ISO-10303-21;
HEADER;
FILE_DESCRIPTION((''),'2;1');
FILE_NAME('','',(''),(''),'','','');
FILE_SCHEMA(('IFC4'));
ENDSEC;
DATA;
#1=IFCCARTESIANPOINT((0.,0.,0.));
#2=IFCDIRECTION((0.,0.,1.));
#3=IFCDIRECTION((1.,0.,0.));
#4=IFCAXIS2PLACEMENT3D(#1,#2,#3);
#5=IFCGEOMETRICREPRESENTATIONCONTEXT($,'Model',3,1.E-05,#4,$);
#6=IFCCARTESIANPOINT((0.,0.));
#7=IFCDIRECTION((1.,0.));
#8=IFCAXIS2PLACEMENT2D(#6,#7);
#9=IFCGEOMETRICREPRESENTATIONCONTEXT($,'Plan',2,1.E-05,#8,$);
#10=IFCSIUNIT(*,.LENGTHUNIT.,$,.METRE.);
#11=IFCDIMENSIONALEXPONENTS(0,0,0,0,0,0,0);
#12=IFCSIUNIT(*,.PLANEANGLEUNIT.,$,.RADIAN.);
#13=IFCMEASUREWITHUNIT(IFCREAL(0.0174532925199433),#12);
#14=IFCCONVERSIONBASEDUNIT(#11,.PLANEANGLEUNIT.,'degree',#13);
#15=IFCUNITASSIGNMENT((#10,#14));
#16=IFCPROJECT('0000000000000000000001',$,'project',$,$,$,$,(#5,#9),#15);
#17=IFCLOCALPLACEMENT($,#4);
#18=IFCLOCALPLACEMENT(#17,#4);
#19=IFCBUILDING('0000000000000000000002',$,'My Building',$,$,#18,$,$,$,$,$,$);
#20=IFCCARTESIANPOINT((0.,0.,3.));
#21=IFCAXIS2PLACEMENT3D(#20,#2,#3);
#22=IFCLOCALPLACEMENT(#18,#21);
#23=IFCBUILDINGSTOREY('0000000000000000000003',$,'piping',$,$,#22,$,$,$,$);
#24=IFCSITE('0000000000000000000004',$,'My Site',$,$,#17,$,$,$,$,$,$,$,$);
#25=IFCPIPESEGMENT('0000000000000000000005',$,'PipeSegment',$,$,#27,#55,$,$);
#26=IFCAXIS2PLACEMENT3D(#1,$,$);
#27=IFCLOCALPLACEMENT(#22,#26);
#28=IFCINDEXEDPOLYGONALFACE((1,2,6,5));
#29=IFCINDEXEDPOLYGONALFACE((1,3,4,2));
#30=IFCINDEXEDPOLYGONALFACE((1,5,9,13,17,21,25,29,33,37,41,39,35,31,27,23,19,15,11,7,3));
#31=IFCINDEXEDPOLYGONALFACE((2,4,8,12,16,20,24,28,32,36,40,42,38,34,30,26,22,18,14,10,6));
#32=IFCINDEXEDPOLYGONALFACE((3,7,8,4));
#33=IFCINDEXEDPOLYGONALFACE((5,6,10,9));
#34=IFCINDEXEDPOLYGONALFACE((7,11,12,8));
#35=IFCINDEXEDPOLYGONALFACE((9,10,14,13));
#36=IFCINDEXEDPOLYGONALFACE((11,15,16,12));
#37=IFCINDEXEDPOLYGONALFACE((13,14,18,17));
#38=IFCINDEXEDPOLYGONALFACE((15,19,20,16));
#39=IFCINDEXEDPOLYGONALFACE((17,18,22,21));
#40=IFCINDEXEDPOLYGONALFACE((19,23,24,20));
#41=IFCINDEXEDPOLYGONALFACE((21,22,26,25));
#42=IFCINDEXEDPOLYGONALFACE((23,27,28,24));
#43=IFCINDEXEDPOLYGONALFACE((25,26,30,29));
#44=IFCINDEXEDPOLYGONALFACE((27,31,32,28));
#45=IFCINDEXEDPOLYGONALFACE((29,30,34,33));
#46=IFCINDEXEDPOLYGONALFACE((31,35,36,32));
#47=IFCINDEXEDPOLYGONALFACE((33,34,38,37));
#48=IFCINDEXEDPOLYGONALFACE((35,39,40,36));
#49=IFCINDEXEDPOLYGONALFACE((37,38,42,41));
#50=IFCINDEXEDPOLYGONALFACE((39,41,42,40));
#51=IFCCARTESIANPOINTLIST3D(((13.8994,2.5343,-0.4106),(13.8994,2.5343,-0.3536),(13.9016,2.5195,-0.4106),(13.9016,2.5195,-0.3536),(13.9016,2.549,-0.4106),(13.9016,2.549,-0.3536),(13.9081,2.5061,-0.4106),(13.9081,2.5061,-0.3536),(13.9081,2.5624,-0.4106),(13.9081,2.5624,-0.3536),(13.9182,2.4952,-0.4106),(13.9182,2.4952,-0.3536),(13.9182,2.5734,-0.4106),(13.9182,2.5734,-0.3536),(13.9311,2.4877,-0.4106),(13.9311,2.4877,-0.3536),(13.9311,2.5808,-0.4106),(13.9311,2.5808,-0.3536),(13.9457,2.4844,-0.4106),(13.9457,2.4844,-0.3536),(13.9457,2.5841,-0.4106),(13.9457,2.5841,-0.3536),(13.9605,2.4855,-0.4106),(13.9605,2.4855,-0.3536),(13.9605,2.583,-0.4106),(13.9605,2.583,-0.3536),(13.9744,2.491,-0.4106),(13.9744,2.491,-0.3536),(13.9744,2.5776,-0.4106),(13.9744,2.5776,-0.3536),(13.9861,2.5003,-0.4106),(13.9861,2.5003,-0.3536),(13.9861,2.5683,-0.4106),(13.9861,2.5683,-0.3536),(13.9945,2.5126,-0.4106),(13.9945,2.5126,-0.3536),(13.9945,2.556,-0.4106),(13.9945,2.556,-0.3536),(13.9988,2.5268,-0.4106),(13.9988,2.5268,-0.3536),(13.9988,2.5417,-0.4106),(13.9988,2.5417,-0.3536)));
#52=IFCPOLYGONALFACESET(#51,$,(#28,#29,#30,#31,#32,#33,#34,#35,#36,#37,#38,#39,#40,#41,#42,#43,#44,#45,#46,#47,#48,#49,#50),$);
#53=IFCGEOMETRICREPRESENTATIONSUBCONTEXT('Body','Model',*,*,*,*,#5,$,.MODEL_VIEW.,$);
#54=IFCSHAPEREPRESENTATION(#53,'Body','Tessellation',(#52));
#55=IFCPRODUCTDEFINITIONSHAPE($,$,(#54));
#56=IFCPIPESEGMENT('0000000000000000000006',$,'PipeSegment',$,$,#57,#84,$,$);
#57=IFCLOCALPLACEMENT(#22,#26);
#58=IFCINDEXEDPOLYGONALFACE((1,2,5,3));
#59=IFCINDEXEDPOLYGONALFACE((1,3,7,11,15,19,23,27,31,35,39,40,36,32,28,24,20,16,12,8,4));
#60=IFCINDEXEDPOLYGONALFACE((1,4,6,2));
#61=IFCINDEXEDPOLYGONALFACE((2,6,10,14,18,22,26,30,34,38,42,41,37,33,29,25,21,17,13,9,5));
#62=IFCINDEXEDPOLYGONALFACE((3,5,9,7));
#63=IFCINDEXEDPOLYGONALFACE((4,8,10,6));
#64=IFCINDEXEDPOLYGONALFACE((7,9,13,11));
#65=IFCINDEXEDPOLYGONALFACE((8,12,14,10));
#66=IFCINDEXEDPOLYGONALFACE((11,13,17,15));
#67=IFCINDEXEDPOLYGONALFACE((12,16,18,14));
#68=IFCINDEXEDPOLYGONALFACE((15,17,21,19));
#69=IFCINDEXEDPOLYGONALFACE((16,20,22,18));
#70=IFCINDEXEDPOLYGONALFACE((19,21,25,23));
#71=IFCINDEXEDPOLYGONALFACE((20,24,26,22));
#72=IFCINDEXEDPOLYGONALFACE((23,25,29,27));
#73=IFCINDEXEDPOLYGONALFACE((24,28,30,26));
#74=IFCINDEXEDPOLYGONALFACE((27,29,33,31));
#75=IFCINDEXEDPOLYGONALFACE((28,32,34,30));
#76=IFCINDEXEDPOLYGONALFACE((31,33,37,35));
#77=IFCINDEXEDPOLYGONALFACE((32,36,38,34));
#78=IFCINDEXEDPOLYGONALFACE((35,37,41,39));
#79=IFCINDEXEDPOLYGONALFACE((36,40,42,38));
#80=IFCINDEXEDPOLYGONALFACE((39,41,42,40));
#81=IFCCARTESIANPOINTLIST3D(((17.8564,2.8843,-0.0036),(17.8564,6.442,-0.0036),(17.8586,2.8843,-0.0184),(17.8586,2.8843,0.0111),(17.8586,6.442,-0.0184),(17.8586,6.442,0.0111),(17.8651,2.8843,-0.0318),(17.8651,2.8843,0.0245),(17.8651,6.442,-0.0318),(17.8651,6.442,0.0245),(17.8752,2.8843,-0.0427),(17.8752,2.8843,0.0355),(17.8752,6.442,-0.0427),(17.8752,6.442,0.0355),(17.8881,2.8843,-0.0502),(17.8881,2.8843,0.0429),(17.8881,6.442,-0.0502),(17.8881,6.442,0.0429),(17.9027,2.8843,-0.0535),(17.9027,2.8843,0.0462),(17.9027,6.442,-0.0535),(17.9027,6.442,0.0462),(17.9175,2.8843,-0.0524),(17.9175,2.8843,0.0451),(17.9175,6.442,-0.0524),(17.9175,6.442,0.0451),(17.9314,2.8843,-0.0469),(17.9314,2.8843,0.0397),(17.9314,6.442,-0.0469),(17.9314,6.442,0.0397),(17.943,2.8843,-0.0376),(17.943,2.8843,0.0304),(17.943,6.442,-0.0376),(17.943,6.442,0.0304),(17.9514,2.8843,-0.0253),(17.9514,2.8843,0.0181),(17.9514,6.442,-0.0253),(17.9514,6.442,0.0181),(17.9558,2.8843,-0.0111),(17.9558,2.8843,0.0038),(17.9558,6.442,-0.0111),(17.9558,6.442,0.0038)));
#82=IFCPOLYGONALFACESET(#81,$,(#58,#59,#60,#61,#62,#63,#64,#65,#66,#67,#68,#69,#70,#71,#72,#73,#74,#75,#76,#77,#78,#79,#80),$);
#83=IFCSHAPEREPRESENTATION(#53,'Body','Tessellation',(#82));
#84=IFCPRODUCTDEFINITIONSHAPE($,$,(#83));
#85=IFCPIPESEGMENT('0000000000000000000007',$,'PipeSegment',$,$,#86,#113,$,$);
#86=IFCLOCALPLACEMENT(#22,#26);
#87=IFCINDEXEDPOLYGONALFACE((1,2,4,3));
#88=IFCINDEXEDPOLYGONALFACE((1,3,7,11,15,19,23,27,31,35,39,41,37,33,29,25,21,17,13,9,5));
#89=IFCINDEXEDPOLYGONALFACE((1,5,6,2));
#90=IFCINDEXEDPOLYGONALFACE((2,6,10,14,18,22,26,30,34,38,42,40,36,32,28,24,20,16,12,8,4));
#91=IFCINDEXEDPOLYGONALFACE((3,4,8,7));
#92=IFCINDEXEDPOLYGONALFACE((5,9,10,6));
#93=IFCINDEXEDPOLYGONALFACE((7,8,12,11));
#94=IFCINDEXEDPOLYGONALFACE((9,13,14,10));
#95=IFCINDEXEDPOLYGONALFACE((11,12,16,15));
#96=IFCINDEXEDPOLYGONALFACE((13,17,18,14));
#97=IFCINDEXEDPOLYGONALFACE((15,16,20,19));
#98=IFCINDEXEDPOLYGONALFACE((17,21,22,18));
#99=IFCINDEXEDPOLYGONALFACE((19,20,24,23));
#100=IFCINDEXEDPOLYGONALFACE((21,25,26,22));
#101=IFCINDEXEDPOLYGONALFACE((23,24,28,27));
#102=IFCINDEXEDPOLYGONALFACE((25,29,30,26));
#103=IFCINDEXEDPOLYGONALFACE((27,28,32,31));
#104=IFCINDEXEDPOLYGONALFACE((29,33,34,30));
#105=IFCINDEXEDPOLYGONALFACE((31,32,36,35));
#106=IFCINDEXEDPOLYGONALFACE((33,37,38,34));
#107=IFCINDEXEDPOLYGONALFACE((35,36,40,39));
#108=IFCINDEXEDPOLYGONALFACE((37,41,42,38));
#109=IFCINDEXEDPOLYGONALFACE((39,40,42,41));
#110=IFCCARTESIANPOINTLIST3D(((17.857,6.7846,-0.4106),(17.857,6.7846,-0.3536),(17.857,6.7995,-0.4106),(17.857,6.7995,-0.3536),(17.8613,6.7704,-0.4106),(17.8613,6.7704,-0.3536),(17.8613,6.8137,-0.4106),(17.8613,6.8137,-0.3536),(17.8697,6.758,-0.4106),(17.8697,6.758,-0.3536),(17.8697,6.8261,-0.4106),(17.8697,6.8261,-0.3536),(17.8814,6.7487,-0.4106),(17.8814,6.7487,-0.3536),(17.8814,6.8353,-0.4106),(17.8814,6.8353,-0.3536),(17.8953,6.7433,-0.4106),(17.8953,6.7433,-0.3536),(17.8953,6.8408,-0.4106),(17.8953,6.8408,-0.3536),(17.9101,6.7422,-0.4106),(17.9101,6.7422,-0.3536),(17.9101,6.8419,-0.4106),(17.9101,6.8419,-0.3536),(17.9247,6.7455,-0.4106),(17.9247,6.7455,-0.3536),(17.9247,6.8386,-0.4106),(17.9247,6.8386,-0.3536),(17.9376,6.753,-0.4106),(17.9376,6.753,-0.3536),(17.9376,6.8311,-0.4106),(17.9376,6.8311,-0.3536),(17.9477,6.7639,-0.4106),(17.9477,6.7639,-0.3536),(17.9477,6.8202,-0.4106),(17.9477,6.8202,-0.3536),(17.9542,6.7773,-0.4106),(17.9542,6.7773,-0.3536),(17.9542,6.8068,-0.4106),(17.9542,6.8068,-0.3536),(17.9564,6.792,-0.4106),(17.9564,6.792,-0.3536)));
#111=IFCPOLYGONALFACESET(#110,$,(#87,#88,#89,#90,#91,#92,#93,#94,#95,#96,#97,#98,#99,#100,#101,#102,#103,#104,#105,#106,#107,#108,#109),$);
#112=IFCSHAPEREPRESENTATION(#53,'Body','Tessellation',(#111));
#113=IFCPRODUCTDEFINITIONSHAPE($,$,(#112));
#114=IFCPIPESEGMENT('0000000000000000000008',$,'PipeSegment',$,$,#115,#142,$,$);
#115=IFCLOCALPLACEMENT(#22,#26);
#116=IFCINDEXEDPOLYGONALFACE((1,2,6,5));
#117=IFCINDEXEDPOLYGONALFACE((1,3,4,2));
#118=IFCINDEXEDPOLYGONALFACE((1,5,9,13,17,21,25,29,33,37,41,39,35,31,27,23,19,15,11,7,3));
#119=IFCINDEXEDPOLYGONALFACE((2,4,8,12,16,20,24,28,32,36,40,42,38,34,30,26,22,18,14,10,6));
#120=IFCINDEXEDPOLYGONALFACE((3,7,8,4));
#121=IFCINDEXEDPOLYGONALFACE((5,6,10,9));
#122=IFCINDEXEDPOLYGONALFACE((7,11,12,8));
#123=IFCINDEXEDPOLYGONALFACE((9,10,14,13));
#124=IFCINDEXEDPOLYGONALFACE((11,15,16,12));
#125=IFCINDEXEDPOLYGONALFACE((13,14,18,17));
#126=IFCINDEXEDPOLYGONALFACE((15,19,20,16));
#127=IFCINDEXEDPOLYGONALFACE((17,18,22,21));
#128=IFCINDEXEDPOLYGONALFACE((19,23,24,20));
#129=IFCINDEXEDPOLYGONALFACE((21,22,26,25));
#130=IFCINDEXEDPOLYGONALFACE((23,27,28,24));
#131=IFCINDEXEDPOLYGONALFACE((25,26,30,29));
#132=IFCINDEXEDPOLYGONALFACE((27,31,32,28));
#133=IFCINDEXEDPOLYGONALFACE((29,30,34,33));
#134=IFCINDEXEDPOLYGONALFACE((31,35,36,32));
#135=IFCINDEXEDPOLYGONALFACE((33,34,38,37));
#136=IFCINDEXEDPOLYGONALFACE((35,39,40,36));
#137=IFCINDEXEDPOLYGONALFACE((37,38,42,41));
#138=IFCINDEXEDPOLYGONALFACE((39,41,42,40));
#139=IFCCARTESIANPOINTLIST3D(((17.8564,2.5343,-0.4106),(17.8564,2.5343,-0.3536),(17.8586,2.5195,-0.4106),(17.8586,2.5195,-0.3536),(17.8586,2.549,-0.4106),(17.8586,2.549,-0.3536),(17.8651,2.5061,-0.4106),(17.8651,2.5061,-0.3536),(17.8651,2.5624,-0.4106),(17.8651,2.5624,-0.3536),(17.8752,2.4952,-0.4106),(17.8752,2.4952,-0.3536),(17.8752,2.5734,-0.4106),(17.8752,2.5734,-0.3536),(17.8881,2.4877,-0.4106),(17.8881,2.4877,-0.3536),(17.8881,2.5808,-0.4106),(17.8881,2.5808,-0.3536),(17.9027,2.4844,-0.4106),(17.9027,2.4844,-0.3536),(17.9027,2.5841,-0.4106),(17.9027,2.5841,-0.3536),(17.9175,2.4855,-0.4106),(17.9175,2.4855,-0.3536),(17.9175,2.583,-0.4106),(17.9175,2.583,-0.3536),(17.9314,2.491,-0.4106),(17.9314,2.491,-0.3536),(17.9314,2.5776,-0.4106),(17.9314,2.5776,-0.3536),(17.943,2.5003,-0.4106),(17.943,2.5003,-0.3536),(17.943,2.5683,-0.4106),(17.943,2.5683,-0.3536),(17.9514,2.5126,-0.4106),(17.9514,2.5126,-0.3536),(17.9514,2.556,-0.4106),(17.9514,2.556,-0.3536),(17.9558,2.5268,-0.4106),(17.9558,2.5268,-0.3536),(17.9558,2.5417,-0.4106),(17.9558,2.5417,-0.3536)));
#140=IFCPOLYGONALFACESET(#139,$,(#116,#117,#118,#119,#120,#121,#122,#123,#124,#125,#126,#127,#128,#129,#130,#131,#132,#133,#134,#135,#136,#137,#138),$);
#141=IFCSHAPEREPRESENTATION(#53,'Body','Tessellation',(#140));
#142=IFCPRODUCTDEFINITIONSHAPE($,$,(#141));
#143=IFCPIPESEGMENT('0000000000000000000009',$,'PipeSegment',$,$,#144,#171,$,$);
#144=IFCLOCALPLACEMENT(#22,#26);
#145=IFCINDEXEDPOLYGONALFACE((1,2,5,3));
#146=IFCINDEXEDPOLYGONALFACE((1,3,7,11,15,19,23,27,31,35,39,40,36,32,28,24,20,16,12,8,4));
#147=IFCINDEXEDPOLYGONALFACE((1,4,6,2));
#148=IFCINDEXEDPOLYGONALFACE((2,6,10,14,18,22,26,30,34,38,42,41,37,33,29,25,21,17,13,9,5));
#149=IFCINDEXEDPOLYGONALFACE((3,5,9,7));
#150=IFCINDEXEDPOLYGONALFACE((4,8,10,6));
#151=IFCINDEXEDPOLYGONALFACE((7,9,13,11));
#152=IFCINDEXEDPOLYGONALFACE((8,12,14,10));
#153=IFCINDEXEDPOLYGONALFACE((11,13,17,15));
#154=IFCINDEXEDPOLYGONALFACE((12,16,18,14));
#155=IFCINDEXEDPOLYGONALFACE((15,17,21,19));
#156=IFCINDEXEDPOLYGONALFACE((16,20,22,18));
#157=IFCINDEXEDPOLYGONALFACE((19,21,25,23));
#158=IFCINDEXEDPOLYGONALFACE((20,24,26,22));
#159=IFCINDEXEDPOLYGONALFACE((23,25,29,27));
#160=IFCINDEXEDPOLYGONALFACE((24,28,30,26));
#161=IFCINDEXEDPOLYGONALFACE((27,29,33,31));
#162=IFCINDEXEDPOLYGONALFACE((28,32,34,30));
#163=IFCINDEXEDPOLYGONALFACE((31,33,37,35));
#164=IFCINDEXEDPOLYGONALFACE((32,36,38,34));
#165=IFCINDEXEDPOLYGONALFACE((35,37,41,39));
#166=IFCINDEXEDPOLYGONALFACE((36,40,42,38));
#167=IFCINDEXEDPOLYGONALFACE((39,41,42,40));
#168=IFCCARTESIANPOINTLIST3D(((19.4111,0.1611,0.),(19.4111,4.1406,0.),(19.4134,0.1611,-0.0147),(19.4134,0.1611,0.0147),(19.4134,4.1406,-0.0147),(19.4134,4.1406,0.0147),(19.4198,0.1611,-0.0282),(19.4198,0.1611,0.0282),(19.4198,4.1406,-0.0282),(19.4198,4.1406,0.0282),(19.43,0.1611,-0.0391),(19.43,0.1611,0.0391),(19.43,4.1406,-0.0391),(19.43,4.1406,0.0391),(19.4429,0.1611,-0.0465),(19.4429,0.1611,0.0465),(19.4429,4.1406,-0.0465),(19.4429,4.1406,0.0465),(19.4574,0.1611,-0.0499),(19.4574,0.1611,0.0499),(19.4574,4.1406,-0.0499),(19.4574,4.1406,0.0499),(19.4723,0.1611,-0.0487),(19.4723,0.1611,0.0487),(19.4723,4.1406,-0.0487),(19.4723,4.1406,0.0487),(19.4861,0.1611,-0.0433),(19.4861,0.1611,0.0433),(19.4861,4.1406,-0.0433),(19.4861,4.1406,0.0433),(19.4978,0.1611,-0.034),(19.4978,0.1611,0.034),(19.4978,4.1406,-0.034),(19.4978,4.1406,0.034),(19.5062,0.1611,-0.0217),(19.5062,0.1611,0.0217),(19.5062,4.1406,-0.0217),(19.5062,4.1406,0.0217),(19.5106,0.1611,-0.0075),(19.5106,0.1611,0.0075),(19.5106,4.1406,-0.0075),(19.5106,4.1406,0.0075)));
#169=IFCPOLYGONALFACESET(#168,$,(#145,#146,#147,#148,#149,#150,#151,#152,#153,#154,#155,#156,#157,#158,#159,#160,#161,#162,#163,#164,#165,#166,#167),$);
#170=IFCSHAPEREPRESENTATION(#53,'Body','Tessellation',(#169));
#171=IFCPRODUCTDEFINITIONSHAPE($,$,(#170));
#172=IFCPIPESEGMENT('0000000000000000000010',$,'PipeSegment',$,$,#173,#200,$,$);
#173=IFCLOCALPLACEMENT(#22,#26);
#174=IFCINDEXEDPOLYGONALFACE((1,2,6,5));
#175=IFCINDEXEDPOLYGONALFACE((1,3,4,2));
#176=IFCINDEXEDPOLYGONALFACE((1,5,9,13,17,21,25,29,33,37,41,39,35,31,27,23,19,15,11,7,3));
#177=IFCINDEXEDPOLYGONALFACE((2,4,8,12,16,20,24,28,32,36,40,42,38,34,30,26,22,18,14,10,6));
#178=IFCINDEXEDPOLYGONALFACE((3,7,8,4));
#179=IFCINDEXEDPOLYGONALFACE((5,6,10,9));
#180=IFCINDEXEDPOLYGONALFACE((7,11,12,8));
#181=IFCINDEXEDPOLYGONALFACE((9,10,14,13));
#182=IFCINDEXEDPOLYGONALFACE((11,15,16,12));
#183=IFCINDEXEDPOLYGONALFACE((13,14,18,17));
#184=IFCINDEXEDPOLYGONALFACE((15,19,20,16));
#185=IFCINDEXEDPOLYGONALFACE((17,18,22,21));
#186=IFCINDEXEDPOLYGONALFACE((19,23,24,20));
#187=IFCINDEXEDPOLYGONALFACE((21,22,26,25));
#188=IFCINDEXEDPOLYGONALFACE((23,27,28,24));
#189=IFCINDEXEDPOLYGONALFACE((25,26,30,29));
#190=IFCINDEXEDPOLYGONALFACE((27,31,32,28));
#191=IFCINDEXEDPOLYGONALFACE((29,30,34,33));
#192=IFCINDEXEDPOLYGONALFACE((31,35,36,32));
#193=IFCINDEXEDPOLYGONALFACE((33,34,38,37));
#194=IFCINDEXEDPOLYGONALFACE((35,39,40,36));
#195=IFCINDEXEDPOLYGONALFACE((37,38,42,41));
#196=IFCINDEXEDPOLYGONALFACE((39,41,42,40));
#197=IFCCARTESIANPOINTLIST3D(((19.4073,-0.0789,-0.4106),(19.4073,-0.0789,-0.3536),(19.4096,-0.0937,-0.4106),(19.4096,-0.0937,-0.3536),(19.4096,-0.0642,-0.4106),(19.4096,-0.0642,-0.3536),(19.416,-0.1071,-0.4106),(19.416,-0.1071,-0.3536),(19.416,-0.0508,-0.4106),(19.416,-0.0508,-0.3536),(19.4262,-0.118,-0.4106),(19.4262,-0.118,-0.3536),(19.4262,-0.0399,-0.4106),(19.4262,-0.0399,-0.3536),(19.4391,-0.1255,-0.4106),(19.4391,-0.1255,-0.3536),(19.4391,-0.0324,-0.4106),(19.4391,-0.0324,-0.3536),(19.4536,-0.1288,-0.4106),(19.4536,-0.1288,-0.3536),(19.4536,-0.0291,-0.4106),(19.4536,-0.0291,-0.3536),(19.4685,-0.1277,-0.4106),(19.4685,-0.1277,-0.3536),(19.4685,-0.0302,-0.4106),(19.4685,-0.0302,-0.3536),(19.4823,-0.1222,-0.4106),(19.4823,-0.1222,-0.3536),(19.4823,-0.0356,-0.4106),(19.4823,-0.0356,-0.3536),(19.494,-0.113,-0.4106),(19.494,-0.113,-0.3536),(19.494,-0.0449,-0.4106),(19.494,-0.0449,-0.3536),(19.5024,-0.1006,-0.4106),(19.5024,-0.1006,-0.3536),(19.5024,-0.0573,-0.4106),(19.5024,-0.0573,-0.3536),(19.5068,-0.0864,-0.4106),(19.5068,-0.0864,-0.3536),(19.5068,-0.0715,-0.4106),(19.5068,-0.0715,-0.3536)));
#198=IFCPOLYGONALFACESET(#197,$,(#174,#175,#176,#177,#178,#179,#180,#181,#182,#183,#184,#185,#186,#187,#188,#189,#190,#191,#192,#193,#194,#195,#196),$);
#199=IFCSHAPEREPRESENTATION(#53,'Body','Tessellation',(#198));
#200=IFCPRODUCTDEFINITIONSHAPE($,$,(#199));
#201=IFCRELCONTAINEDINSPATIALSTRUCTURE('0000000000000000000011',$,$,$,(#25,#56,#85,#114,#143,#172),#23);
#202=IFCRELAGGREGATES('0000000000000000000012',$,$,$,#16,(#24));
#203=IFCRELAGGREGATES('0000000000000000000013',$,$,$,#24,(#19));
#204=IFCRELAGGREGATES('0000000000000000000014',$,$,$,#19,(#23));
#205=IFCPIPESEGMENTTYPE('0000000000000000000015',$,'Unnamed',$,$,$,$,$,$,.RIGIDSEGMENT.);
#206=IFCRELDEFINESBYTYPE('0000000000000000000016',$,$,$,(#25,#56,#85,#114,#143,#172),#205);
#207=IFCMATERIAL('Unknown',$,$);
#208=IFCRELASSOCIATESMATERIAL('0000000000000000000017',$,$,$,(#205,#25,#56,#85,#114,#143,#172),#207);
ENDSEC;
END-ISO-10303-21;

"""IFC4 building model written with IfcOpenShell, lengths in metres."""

from ifc_helpers import new_model, entity, si_unit, converted_unit, frame, origin_with_axes, origin_2d_with_axis, place, context, subcontext, project, spatial, circle, extrude, material, material_profile, profile_set, profile_usage, type_object, element, save


model = new_model("IFC4")

# Units and contexts
model_context = context("Model", 3, precision=1e-05, world=origin_with_axes())
plan_context = context("Plan", 2, precision=1e-05, world=origin_2d_with_axis())
body_context = subcontext(model_context, "Body", "Model", "MODEL_VIEW")
ifc_project = project(units=[si_unit("LENGTHUNIT", "METRE"), converted_unit("PLANEANGLEUNIT", "degree", entity("IfcReal", 0.0174532925199433), si_unit("PLANEANGLEUNIT", "RADIAN"), dimensions=[0, 0, 0, 0, 0, 0, 0])], contexts=[model_context, plan_context])

# Site, building, storey
site_placement = place(None, origin_with_axes())
site = spatial("IfcSite", under=ifc_project, at=site_placement, Name="My Site")
building_placement = place(site_placement, origin_with_axes())
building = spatial("IfcBuilding", under=site, at=building_placement, Name="My Building")
storey_placement = place(building_placement, frame((0.0, 0.0, 3.0), z_axis=(0.0, 0.0, 1.0), x_axis=(1.0, 0.0, 0.0)))
storey = spatial("IfcBuildingStorey", under=building, at=storey_placement, Name="piping")

# Pipe segments
ifc_material = material(Name="Unknown")
ifc_material_profile = material_profile(ifc_material, circle(Radius=0.05))
ifc_profile_set = profile_set([ifc_material_profile])
pipe_segment_type = type_object("IfcPipeSegmentType", Name="Unnamed", PredefinedType="RIGIDSEGMENT", material=ifc_profile_set)
ifc_profile_usage_1 = profile_usage(ifc_profile_set, cardinal=5)
pipe_segment_1_placement = place(storey_placement, frame((13.9494, 2.5343, -0.3536), z_axis=(0.0, 0.0, -1.0), x_axis=(-1.0, 0.0, 0.0)))
element("IfcPipeSegment", 1, at=pipe_segment_1_placement, inside=storey, type_object=pipe_segment_type, material=ifc_profile_usage_1, Name="PipeSegment", context=body_context, shape_type="SweptSolid", body=[
    extrude(circle(Radius=0.05), origin_with_axes(), (0.0, 0.0, 1.0), 0.057),
])
ifc_profile_usage_2 = profile_usage(ifc_profile_set, cardinal=5)
pipe_segment_2_placement = place(storey_placement, frame((17.9064, 2.8843, -0.0036), z_axis=(0.0, 1.0, 0.0), x_axis=(-1.0, 0.0, 0.0)))
element("IfcPipeSegment", 2, at=pipe_segment_2_placement, inside=storey, type_object=pipe_segment_type, material=ifc_profile_usage_2, Name="PipeSegment", context=body_context, shape_type="SweptSolid", body=[
    extrude(circle(Radius=0.05), origin_with_axes(), (0.0, 0.0, 1.0), 3.5578),
])
ifc_profile_usage_3 = profile_usage(ifc_profile_set, cardinal=5)
pipe_segment_3_placement = place(storey_placement, frame((17.9064, 6.792, -0.3536), z_axis=(0.0, 0.0, -1.0), x_axis=(1.0, 0.0, 0.0)))
element("IfcPipeSegment", 3, at=pipe_segment_3_placement, inside=storey, type_object=pipe_segment_type, material=ifc_profile_usage_3, Name="PipeSegment", context=body_context, shape_type="SweptSolid", body=[
    extrude(circle(Radius=0.05), origin_with_axes(), (0.0, 0.0, 1.0), 0.057),
])
ifc_profile_usage_4 = profile_usage(ifc_profile_set, cardinal=5)
pipe_segment_4_placement = place(storey_placement, frame((17.9064, 2.5343, -0.3536), z_axis=(0.0, 0.0, -1.0), x_axis=(-1.0, 0.0, 0.0)))
element("IfcPipeSegment", 4, at=pipe_segment_4_placement, inside=storey, type_object=pipe_segment_type, material=ifc_profile_usage_4, Name="PipeSegment", context=body_context, shape_type="SweptSolid", body=[
    extrude(circle(Radius=0.05), origin_with_axes(), (0.0, 0.0, 1.0), 0.057),
])
ifc_profile_usage_5 = profile_usage(ifc_profile_set, cardinal=5)
pipe_segment_5_placement = place(storey_placement, frame((19.4611, 0.1611, 0.0), z_axis=(0.0, 1.0, 0.0), x_axis=(-1.0, 0.0, 0.0)))
element("IfcPipeSegment", 5, at=pipe_segment_5_placement, inside=storey, type_object=pipe_segment_type, material=ifc_profile_usage_5, Name="PipeSegment", context=body_context, shape_type="SweptSolid", body=[
    extrude(circle(Radius=0.05), origin_with_axes(), (0.0, 0.0, 1.0), 3.9795),
])
ifc_profile_usage_6 = profile_usage(ifc_profile_set, cardinal=5)
pipe_segment_6_placement = place(storey_placement, frame((19.4573, -0.0789, -0.3536), z_axis=(0.0, 0.0, -1.0), x_axis=(-1.0, 0.0, 0.0)))
element("IfcPipeSegment", 6, at=pipe_segment_6_placement, inside=storey, type_object=pipe_segment_type, material=ifc_profile_usage_6, Name="PipeSegment", context=body_context, shape_type="SweptSolid", body=[
    extrude(circle(Radius=0.05), origin_with_axes(), (0.0, 0.0, 1.0), 0.057),
])

save(model, "model.ifc")
